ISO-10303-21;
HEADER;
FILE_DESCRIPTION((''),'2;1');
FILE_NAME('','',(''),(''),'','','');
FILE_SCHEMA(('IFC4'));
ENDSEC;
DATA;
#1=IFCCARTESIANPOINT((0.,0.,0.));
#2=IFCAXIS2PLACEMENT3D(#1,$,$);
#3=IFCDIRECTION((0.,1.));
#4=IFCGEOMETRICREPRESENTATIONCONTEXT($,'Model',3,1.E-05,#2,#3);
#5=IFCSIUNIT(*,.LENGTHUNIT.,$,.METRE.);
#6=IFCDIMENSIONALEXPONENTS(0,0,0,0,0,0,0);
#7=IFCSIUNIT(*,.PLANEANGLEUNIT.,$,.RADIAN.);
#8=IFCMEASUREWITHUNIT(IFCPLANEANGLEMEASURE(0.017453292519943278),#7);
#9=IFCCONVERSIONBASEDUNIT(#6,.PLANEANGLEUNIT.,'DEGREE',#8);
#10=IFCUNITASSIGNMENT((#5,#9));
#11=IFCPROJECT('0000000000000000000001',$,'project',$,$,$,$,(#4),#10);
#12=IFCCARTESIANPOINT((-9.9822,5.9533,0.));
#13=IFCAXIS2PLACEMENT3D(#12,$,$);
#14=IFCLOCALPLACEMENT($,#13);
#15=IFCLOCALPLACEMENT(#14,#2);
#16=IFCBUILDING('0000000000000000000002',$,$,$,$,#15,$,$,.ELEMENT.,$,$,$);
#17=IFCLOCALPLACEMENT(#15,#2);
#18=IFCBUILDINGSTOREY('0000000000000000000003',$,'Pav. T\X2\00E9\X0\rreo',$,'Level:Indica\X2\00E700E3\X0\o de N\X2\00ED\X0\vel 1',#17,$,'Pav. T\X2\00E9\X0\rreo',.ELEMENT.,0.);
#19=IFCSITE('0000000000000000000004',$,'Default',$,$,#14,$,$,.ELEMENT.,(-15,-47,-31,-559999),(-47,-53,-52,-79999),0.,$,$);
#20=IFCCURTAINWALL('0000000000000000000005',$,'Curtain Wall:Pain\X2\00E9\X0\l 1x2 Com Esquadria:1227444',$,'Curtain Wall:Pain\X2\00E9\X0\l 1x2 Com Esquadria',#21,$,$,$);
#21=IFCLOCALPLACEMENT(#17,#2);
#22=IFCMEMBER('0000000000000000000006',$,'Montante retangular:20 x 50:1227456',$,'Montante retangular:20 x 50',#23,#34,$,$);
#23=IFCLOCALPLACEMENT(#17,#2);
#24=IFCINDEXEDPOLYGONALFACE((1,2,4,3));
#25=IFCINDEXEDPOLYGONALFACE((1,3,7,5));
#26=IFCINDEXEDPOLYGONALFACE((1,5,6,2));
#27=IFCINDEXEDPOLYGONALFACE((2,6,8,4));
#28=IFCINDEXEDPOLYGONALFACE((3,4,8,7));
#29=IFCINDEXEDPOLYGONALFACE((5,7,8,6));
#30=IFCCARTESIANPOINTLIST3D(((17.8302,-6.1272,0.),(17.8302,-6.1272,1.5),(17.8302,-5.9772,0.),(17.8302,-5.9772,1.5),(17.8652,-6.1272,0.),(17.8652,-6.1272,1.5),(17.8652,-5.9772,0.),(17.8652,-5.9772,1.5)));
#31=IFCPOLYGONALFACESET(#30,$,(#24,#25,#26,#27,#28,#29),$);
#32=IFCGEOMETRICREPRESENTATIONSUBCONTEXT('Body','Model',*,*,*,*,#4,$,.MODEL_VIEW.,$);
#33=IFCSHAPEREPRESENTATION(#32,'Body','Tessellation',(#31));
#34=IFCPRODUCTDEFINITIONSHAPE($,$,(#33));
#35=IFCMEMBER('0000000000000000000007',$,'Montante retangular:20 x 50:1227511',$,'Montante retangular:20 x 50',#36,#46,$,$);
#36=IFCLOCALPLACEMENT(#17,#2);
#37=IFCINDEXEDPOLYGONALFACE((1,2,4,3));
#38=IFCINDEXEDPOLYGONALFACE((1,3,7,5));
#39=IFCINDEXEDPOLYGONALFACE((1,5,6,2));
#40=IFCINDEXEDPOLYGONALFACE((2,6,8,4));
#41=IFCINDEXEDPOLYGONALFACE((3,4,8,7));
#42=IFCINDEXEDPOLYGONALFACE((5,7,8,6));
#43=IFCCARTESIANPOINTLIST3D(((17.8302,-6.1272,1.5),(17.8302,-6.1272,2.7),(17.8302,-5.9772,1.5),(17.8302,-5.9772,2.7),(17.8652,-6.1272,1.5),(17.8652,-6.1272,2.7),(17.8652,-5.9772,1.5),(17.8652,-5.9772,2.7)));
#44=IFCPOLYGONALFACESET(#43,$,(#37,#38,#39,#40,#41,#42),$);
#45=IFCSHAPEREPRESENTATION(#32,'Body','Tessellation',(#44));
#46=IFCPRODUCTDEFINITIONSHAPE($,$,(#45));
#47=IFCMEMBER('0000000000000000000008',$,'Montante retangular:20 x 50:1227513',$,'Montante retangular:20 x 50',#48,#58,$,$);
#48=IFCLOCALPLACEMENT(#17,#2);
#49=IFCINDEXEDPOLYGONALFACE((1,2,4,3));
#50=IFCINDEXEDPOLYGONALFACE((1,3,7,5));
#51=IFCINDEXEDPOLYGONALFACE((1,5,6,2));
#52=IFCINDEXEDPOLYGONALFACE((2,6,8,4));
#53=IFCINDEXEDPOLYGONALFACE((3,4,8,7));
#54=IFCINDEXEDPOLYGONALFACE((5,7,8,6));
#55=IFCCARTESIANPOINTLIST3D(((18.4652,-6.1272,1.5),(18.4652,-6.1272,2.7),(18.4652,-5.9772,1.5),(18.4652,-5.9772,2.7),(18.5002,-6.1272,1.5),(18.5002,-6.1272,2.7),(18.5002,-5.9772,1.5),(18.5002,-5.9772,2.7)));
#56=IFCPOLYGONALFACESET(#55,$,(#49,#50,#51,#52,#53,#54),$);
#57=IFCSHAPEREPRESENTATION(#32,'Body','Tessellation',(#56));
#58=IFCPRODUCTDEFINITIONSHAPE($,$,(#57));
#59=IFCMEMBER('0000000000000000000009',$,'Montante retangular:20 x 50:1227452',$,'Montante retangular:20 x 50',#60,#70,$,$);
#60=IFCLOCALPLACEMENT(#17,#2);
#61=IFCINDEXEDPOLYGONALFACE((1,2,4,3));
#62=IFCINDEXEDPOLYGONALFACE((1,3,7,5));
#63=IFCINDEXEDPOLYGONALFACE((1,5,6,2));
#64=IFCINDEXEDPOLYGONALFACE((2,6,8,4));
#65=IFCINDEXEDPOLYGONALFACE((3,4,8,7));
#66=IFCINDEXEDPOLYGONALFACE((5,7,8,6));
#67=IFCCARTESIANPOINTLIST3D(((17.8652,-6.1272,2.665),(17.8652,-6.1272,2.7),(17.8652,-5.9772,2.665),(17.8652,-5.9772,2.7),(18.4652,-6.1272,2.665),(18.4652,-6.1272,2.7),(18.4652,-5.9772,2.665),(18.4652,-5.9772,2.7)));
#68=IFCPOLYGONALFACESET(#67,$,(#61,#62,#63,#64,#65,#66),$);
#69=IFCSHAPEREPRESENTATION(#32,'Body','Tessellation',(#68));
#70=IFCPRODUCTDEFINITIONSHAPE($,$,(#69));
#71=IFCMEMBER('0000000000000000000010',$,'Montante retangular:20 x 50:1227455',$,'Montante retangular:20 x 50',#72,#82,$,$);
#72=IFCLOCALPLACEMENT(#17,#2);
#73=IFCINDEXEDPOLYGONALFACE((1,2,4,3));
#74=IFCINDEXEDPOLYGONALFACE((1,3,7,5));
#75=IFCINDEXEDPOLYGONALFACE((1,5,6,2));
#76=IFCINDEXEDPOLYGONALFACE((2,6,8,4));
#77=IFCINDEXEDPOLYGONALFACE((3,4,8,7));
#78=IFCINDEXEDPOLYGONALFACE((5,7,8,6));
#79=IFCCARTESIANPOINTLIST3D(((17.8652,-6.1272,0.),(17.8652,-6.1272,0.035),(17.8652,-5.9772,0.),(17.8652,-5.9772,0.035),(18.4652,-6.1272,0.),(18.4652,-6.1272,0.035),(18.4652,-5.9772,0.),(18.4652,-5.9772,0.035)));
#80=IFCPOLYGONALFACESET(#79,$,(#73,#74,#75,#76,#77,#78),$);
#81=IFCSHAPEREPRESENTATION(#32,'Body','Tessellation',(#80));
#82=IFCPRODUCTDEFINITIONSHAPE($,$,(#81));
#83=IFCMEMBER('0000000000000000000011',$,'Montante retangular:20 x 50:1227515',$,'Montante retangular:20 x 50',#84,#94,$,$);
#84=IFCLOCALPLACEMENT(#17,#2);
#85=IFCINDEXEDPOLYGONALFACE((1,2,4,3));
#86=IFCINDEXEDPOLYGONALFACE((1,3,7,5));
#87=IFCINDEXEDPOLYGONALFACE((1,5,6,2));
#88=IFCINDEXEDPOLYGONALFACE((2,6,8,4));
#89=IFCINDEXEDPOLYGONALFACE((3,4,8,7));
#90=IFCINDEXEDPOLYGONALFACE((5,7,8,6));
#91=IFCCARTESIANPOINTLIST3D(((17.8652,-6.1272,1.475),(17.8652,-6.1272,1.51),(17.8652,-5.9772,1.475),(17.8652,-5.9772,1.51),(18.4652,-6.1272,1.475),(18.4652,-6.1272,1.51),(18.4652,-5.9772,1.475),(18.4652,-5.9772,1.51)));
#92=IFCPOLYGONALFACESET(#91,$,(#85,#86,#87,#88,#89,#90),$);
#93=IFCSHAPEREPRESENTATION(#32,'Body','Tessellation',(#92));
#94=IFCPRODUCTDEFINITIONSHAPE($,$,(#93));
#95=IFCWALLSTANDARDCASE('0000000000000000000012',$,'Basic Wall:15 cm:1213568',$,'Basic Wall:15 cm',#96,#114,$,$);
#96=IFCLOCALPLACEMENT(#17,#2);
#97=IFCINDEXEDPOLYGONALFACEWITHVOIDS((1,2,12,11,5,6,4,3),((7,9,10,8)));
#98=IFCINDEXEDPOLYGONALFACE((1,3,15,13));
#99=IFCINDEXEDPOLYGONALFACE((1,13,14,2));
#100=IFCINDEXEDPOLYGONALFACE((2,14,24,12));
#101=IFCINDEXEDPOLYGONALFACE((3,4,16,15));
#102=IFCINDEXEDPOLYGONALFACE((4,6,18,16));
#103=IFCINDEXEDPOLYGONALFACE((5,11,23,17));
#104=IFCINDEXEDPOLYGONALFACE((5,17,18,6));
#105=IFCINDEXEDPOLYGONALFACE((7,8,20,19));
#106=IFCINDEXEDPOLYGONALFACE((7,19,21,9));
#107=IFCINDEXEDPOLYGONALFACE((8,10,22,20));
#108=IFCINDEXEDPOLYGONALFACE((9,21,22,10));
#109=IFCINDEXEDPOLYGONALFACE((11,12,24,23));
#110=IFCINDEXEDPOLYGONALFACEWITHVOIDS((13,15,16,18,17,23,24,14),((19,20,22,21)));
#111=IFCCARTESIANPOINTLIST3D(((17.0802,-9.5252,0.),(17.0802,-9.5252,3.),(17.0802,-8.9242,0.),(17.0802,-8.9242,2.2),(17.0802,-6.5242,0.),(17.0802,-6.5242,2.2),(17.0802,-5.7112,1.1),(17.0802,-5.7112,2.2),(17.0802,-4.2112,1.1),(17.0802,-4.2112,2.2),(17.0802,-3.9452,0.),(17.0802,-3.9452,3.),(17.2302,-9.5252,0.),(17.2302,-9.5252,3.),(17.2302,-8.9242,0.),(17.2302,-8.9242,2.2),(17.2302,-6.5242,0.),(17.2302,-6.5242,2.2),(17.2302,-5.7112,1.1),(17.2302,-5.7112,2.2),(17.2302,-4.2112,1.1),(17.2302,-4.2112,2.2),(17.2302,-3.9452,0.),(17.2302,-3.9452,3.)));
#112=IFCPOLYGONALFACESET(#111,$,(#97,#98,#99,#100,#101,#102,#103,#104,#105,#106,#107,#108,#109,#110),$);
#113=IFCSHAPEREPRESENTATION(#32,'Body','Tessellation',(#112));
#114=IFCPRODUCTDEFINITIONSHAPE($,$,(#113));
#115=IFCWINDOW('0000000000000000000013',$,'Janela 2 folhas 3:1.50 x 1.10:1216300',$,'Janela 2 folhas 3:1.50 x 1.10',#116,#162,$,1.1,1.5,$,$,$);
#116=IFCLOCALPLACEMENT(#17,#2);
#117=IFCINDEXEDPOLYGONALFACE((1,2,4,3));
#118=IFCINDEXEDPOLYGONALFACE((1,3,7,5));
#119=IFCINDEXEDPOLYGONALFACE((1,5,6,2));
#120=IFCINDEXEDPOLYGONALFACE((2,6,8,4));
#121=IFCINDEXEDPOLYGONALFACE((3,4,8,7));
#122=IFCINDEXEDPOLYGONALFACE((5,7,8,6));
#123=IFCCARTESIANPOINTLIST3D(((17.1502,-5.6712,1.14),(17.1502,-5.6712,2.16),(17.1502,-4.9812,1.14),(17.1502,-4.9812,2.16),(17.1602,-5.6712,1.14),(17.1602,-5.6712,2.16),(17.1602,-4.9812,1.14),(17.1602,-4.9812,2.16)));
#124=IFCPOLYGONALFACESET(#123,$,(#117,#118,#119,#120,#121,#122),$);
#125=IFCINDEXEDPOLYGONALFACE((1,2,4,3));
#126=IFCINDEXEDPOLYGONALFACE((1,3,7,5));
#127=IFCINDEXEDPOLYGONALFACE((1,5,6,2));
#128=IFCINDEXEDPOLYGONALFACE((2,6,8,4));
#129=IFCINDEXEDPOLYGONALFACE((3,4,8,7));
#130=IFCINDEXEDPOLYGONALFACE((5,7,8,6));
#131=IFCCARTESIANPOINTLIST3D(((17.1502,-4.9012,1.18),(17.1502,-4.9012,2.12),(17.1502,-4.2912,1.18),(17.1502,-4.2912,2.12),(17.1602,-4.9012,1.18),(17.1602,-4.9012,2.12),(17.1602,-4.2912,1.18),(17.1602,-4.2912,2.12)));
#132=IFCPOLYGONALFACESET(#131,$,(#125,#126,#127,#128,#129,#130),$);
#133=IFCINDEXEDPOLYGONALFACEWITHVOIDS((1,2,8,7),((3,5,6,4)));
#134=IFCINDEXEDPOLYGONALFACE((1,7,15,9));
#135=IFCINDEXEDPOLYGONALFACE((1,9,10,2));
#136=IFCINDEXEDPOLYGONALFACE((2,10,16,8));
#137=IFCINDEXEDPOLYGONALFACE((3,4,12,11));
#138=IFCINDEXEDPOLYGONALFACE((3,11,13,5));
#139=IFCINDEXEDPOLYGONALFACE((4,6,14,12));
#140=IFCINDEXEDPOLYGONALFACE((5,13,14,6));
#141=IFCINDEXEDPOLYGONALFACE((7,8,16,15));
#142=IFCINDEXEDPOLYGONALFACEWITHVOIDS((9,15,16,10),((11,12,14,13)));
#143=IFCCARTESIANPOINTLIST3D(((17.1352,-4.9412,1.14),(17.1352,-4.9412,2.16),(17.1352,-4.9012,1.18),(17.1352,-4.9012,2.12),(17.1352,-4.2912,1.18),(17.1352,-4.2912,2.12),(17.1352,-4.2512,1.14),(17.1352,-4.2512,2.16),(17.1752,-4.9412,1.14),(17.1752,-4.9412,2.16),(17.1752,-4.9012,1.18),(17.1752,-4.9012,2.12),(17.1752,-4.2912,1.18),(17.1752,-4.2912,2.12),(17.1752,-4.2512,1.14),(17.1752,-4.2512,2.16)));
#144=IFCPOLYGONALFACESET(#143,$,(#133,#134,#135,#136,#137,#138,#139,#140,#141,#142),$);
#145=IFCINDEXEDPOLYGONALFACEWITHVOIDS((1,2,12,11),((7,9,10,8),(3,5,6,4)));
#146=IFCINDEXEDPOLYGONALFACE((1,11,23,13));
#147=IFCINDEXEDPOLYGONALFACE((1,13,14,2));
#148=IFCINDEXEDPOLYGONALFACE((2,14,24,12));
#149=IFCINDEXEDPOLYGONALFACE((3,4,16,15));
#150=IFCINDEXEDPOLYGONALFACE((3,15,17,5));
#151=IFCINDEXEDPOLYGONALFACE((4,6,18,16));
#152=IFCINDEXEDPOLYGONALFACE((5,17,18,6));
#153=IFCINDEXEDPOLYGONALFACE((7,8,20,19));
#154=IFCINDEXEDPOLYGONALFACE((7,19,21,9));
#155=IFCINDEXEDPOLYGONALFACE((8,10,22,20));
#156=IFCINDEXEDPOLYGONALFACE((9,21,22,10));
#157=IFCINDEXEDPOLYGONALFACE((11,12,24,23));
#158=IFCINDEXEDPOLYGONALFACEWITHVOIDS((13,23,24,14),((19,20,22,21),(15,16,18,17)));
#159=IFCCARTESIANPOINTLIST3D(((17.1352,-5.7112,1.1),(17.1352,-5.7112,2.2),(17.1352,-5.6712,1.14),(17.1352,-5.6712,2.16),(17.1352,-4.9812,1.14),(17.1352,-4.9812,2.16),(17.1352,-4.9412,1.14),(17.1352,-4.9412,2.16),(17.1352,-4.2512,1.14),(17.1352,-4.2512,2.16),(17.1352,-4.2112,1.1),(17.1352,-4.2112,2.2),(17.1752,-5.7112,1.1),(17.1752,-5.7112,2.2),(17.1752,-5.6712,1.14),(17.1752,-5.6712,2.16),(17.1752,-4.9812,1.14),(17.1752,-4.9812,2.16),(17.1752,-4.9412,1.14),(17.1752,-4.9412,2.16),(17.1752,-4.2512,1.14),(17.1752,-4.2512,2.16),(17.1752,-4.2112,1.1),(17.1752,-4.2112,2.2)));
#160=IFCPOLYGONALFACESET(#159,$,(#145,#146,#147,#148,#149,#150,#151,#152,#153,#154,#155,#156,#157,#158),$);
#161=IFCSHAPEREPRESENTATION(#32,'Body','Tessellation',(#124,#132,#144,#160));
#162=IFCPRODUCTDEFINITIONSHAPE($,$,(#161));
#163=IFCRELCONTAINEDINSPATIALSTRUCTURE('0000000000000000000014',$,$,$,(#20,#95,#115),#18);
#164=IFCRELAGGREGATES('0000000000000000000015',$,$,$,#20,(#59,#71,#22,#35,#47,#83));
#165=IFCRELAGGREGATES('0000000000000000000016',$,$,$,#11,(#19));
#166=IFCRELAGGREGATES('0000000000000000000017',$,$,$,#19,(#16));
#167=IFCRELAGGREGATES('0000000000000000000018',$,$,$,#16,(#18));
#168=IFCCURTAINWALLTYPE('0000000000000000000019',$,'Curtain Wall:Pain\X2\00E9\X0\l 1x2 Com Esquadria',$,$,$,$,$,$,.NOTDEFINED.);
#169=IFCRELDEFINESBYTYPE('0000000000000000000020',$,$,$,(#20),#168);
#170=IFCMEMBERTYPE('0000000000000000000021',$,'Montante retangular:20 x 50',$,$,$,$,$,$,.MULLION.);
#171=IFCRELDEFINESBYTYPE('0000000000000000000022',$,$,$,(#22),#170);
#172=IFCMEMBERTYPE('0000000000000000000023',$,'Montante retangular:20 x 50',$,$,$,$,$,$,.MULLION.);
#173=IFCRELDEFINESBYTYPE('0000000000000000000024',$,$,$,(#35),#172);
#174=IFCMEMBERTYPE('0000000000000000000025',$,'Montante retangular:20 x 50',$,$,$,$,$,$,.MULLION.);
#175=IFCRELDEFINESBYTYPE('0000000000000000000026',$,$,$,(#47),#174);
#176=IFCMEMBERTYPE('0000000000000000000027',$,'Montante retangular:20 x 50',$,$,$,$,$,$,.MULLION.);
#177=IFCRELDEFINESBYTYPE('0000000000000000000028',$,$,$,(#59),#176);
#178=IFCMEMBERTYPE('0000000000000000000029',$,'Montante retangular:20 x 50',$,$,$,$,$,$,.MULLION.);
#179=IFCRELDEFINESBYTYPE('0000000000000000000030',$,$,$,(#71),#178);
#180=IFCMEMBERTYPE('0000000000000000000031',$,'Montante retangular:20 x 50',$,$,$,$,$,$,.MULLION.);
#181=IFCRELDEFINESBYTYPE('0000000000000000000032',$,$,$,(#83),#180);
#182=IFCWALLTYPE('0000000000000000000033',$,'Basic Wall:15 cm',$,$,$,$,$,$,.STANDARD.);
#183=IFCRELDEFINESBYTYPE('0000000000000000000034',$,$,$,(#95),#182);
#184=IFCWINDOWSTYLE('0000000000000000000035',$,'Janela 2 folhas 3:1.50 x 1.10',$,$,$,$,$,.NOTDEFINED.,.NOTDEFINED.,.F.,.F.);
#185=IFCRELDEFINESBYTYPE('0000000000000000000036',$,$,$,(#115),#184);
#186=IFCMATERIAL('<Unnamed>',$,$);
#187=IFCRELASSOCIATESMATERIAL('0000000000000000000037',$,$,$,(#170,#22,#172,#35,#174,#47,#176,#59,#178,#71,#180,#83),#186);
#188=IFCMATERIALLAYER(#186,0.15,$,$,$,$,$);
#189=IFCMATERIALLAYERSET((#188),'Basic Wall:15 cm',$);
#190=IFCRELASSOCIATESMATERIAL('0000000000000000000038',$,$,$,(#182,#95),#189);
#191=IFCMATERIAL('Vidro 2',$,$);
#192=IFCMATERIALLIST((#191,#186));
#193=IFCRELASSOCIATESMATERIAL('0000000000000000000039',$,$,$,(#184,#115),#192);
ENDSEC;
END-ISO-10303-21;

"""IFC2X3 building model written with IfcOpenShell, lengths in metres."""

from ifc_helpers import new_model, entity, si_unit, converted_unit, direction, frame, frame_2d, origin, origin_2d_with_axis, place, context, subcontext, project, spatial, polyline, rectangle, outline, extrude, source, transform, mapped, material, material_list, layer, layer_set, layer_usage, type_object, type_shapes, element, fill, aggregate, save


model = new_model("IFC2X3")

# Units and contexts
model_context = context("Model", 3, precision=1e-05, world=origin(), true_north=direction((0.0, 1.0)))
body_context = subcontext(model_context, "Body", "Model", "MODEL_VIEW")
ifc_project = project(units=[si_unit("LENGTHUNIT", "METRE"), converted_unit("PLANEANGLEUNIT", "DEGREE", entity("IfcPlaneAngleMeasure", 0.017453292519943278), si_unit("PLANEANGLEUNIT", "RADIAN"), dimensions=[0, 0, 0, 0, 0, 0, 0])], contexts=[model_context])

# Site, building, storey
site_placement = place(None, frame((-9.9822, 5.9533, 0.0)))
site = spatial("IfcSite", under=ifc_project, at=site_placement, Name="Default", CompositionType="ELEMENT", RefLatitude=(-15, -47, -31, -559999), RefLongitude=(-47, -53, -52, -79999), RefElevation=0.0)
building_placement = place(site_placement, origin())
building = spatial("IfcBuilding", under=site, at=building_placement, CompositionType="ELEMENT")
storey_placement = place(building_placement, origin())
storey = spatial("IfcBuildingStorey", under=building, at=storey_placement, Name="Pav. Térreo", ObjectType="Level:Indicação de Nível 1", LongName="Pav. Térreo", CompositionType="ELEMENT", Elevation=0.0)

# Curtain wall, members
curtain_wall_type = type_object("IfcCurtainWallType", Name="Curtain Wall:Painél 1x2 Com Esquadria", PredefinedType="NOTDEFINED")
curtain_wall_placement = place(storey_placement, origin())
curtain_wall = element("IfcCurtainWall", 1, at=curtain_wall_placement, inside=storey, type_object=curtain_wall_type, Name="Curtain Wall:Painél 1x2 Com Esquadria:1227444", ObjectType="Curtain Wall:Painél 1x2 Com Esquadria")
ifc_material_1 = material(Name="<Unnamed>")
member_type_1 = type_object("IfcMemberType", Name="Montante retangular:20 x 50", PredefinedType="MULLION", material=ifc_material_1)
shared_shape_1 = source(origin(), body_context, "Body", "SweptSolid", [
    extrude(rectangle(XDim=0.035, YDim=0.15, at=origin_2d_with_axis()), frame((-0.0175, 0.0, -1.5), z_axis=(0.0, 0.0, 1.0), x_axis=(-1.0, 0.0, 0.0)), (0.0, 0.0, 1.0), 1.5),
])
type_shapes(member_type_1, [shared_shape_1])
member_1_placement = place(curtain_wall_placement, frame((17.8302, -6.0522, 0.0), z_axis=(0.0, 0.0, -1.0), x_axis=(-1.0, 0.0, 0.0)))
member_1 = element("IfcMember", 2, at=member_1_placement, type_object=member_type_1, material=ifc_material_1, Name="Montante retangular:20 x 50:1227456", ObjectType="Montante retangular:20 x 50", context=body_context, shape_type="MappedRepresentation", body=[
    mapped(shared_shape_1, transform((0.0, 0.0, 0.0), scale=1.0)),
])
member_type_2 = type_object("IfcMemberType", Name="Montante retangular:20 x 50", PredefinedType="MULLION", material=ifc_material_1)
shared_shape_2 = source(origin(), body_context, "Body", "SweptSolid", [
    extrude(rectangle(XDim=0.035, YDim=0.15, at=origin_2d_with_axis()), frame((-0.0175, 0.0, -1.2), z_axis=(0.0, 0.0, 1.0), x_axis=(-1.0, 0.0, 0.0)), (0.0, 0.0, 1.0), 1.2),
])
type_shapes(member_type_2, [shared_shape_2])
member_2_placement = place(curtain_wall_placement, frame((17.8302, -6.0522, 1.5), z_axis=(0.0, 0.0, -1.0), x_axis=(-1.0, 0.0, 0.0)))
member_2 = element("IfcMember", 3, at=member_2_placement, type_object=member_type_2, material=ifc_material_1, Name="Montante retangular:20 x 50:1227511", ObjectType="Montante retangular:20 x 50", context=body_context, shape_type="MappedRepresentation", body=[
    mapped(shared_shape_2, transform((0.0, 0.0, 0.0), scale=1.0)),
])
member_type_3 = type_object("IfcMemberType", Name="Montante retangular:20 x 50", PredefinedType="MULLION", material=ifc_material_1)
shared_shape_3 = source(origin(), body_context, "Body", "SweptSolid", [
    extrude(rectangle(XDim=0.035, YDim=0.15, at=origin_2d_with_axis()), frame((-0.0075, 0.0, -1.2), z_axis=(0.0, 0.0, 1.0), x_axis=(-1.0, 0.0, 0.0)), (0.0, 0.0, 1.0), 1.2),
])
type_shapes(member_type_3, [shared_shape_3])
member_3_placement = place(curtain_wall_placement, frame((18.4752, -6.0522, 1.5), z_axis=(0.0, 0.0, -1.0), x_axis=(-1.0, 0.0, 0.0)))
member_3 = element("IfcMember", 4, at=member_3_placement, type_object=member_type_3, material=ifc_material_1, Name="Montante retangular:20 x 50:1227513", ObjectType="Montante retangular:20 x 50", context=body_context, shape_type="MappedRepresentation", body=[
    mapped(shared_shape_3, transform((0.0, 0.0, 0.0), scale=1.0)),
])
member_type_4 = type_object("IfcMemberType", Name="Montante retangular:20 x 50", PredefinedType="MULLION", material=ifc_material_1)
shared_shape_4 = source(origin(), body_context, "Body", "SweptSolid", [
    extrude(rectangle(XDim=0.035, YDim=0.15, at=origin_2d_with_axis()), frame((-0.0175, 0.0, -0.6), z_axis=(0.0, 0.0, 1.0), x_axis=(-1.0, 0.0, 0.0)), (0.0, 0.0, 1.0), 0.6),
])
type_shapes(member_type_4, [shared_shape_4])
member_4_placement = place(curtain_wall_placement, frame((17.8652, -6.0522, 2.7), z_axis=(-1.0, 0.0, 0.0), x_axis=(0.0, 0.0, 1.0)))
member_4 = element("IfcMember", 5, at=member_4_placement, type_object=member_type_4, material=ifc_material_1, Name="Montante retangular:20 x 50:1227452", ObjectType="Montante retangular:20 x 50", context=body_context, shape_type="MappedRepresentation", body=[
    mapped(shared_shape_4, transform((0.0, 0.0, 0.0), scale=1.0)),
])
member_type_5 = type_object("IfcMemberType", Name="Montante retangular:20 x 50", PredefinedType="MULLION", material=ifc_material_1)
shared_shape_5 = source(origin(), body_context, "Body", "SweptSolid", [
    extrude(rectangle(XDim=0.035, YDim=0.15, at=origin_2d_with_axis()), frame((-0.0175, 0.0, -0.6), z_axis=(0.0, 0.0, 1.0), x_axis=(-1.0, 0.0, 0.0)), (0.0, 0.0, 1.0), 0.6),
])
type_shapes(member_type_5, [shared_shape_5])
member_5_placement = place(curtain_wall_placement, frame((18.4652, -6.0522, 0.0), z_axis=(1.0, 0.0, 0.0), x_axis=(0.0, 0.0, -1.0)))
member_5 = element("IfcMember", 6, at=member_5_placement, type_object=member_type_5, material=ifc_material_1, Name="Montante retangular:20 x 50:1227455", ObjectType="Montante retangular:20 x 50", context=body_context, shape_type="MappedRepresentation", body=[
    mapped(shared_shape_5, transform((0.0, 0.0, 0.0), scale=1.0)),
])
member_type_6 = type_object("IfcMemberType", Name="Montante retangular:20 x 50", PredefinedType="MULLION", material=ifc_material_1)
shared_shape_6 = source(origin(), body_context, "Body", "SweptSolid", [
    extrude(rectangle(XDim=0.035, YDim=0.15, at=origin_2d_with_axis()), frame((-0.0075, 0.0, -0.6), z_axis=(0.0, 0.0, 1.0), x_axis=(-1.0, 0.0, 0.0)), (0.0, 0.0, 1.0), 0.6),
])
type_shapes(member_type_6, [shared_shape_6])
member_6_placement = place(curtain_wall_placement, frame((17.8652, -6.0522, 1.5), z_axis=(-1.0, 0.0, 0.0), x_axis=(0.0, 0.0, 1.0)))
member_6 = element("IfcMember", 7, at=member_6_placement, type_object=member_type_6, material=ifc_material_1, Name="Montante retangular:20 x 50:1227515", ObjectType="Montante retangular:20 x 50", context=body_context, shape_type="MappedRepresentation", body=[
    mapped(shared_shape_6, transform((0.0, 0.0, 0.0), scale=1.0)),
])
aggregate(curtain_wall, [member_4, member_5, member_1, member_2, member_3, member_6])

# Wall, openings, window
ifc_layer = layer(ifc_material_1, 0.15)
ifc_layer_set = layer_set([ifc_layer], Name="Basic Wall:15 cm")
ifc_layer_usage_1 = layer_usage(ifc_layer_set, "AXIS2", "NEGATIVE", 0.075)
wall_type = type_object("IfcWallType", Name="Basic Wall:15 cm", PredefinedType="STANDARD", material=ifc_layer_set)
wall_1_placement = place(storey_placement, frame((17.1552, -3.9452, 0.0), z_axis=(0.0, 0.0, 1.0), x_axis=(0.0, -1.0, 0.0)))
wall_1 = element("IfcWallStandardCase", 8, at=wall_1_placement, inside=storey, type_object=wall_type, material=ifc_layer_usage_1, Name="Basic Wall:15 cm:1213568", ObjectType="Basic Wall:15 cm", context=body_context, shape_type="SweptSolid", body=[
    extrude(rectangle(XDim=5.58, YDim=0.15, at=frame_2d((2.79, 0.0), x_axis=(-1.0, 0.0))), origin(), (0.0, 0.0, 1.0), 3.0),
])
opening_1_placement = place(wall_1_placement, origin())
element("IfcOpeningElement", 9, at=opening_1_placement, cuts=wall_1, ObjectType="Opening", context=body_context, shape_type="SweptSolid", body=[
    extrude(rectangle(XDim=2.2, YDim=2.4, at=frame_2d((0.0, 0.0), x_axis=(0.0, 1.0))), frame((3.779, 0.075, 1.1), z_axis=(0.0, -1.0, 0.0), x_axis=(1.0, 0.0, 0.0)), (0.0, 0.0, 1.0), 0.15),
])
opening_2_placement = place(wall_1_placement, frame((1.766, 0.075, 1.1)))
opening_2 = element("IfcOpeningElement", 10, at=opening_2_placement, cuts=wall_1, ObjectType="Opening", context=body_context, shape_type="SweptSolid", body=[
    extrude(rectangle(XDim=1.1, YDim=1.5, at=frame_2d((0.55, 0.75), x_axis=(1.0, 0.0))), frame((0.0, 0.0, 0.0), z_axis=(0.0, -1.0, 0.0), x_axis=(0.0, 0.0, 1.0)), (0.0, 0.0, 1.0), 0.15),
])
ifc_material_2 = material(Name="Vidro 2")
ifc_material_list_1 = material_list([ifc_material_2, ifc_material_1])
window_style = type_object("IfcWindowStyle", Name="Janela 2 folhas 3:1.50 x 1.10", ConstructionType="NOTDEFINED", OperationType="NOTDEFINED", ParameterTakesPrecedence=False, Sizeable=False, material=ifc_material_list_1)
shared_shape_7 = source(origin(), body_context, "Body", "SweptSolid", [
    extrude(rectangle(XDim=0.01, YDim=0.69, at=origin_2d_with_axis()), frame((0.385, 0.075, 0.04), z_axis=(0.0, 0.0, 1.0), x_axis=(0.0, 1.0, 0.0)), (0.0, 0.0, 1.0), 1.02),
    extrude(rectangle(XDim=0.01, YDim=0.61, at=origin_2d_with_axis()), frame((1.115, 0.075, 0.08), z_axis=(0.0, 0.0, 1.0), x_axis=(0.0, 1.0, 0.0)), (0.0, 0.0, 1.0), 0.94),
    extrude(outline(polyline([(-0.345, -0.51), (0.345, -0.51), (0.345, 0.51), (-0.345, 0.51), (-0.345, -0.51)]), holes=[polyline([(-0.305, -0.47), (-0.305, 0.47), (0.305, 0.47), (0.305, -0.47), (-0.305, -0.47)])]), frame((1.115, 0.055, 0.55), z_axis=(0.0, 1.0, 0.0), x_axis=(1.0, 0.0, 0.0)), (0.0, 0.0, 1.0), 0.04),
    extrude(outline(polyline([(-0.55, -0.75), (0.55, -0.75), (0.55, 0.75), (-0.55, 0.75), (-0.55, -0.75)]), holes=[polyline([(0.51, -0.02), (0.51, -0.71), (-0.51, -0.71), (-0.51, -0.02), (0.51, -0.02)]), polyline([(-0.51, 0.02), (-0.51, 0.71), (0.51, 0.71), (0.51, 0.02), (-0.51, 0.02)])]), frame((0.75, 0.055, 0.55), z_axis=(0.0, 1.0, 0.0), x_axis=(0.0, 0.0, -1.0)), (0.0, 0.0, 1.0), 0.04),
])
type_shapes(window_style, [shared_shape_7])
window_placement = place(opening_2_placement, frame((0.0, 0.0, 0.0), z_axis=(0.0, 0.0, 1.0), x_axis=(-1.0, 0.0, 0.0)))
window = element("IfcWindow", 11, at=window_placement, inside=storey, type_object=window_style, material=ifc_material_list_1, Name="Janela 2 folhas 3:1.50 x 1.10:1216300", ObjectType="Janela 2 folhas 3:1.50 x 1.10", OverallHeight=1.1, OverallWidth=1.5, context=body_context, shape_type="MappedRepresentation", body=[
    mapped(shared_shape_7, transform((0.0, 0.0, 0.0), scale=1.0)),
])
fill(opening_2, window)

save(model, "model.ifc")
